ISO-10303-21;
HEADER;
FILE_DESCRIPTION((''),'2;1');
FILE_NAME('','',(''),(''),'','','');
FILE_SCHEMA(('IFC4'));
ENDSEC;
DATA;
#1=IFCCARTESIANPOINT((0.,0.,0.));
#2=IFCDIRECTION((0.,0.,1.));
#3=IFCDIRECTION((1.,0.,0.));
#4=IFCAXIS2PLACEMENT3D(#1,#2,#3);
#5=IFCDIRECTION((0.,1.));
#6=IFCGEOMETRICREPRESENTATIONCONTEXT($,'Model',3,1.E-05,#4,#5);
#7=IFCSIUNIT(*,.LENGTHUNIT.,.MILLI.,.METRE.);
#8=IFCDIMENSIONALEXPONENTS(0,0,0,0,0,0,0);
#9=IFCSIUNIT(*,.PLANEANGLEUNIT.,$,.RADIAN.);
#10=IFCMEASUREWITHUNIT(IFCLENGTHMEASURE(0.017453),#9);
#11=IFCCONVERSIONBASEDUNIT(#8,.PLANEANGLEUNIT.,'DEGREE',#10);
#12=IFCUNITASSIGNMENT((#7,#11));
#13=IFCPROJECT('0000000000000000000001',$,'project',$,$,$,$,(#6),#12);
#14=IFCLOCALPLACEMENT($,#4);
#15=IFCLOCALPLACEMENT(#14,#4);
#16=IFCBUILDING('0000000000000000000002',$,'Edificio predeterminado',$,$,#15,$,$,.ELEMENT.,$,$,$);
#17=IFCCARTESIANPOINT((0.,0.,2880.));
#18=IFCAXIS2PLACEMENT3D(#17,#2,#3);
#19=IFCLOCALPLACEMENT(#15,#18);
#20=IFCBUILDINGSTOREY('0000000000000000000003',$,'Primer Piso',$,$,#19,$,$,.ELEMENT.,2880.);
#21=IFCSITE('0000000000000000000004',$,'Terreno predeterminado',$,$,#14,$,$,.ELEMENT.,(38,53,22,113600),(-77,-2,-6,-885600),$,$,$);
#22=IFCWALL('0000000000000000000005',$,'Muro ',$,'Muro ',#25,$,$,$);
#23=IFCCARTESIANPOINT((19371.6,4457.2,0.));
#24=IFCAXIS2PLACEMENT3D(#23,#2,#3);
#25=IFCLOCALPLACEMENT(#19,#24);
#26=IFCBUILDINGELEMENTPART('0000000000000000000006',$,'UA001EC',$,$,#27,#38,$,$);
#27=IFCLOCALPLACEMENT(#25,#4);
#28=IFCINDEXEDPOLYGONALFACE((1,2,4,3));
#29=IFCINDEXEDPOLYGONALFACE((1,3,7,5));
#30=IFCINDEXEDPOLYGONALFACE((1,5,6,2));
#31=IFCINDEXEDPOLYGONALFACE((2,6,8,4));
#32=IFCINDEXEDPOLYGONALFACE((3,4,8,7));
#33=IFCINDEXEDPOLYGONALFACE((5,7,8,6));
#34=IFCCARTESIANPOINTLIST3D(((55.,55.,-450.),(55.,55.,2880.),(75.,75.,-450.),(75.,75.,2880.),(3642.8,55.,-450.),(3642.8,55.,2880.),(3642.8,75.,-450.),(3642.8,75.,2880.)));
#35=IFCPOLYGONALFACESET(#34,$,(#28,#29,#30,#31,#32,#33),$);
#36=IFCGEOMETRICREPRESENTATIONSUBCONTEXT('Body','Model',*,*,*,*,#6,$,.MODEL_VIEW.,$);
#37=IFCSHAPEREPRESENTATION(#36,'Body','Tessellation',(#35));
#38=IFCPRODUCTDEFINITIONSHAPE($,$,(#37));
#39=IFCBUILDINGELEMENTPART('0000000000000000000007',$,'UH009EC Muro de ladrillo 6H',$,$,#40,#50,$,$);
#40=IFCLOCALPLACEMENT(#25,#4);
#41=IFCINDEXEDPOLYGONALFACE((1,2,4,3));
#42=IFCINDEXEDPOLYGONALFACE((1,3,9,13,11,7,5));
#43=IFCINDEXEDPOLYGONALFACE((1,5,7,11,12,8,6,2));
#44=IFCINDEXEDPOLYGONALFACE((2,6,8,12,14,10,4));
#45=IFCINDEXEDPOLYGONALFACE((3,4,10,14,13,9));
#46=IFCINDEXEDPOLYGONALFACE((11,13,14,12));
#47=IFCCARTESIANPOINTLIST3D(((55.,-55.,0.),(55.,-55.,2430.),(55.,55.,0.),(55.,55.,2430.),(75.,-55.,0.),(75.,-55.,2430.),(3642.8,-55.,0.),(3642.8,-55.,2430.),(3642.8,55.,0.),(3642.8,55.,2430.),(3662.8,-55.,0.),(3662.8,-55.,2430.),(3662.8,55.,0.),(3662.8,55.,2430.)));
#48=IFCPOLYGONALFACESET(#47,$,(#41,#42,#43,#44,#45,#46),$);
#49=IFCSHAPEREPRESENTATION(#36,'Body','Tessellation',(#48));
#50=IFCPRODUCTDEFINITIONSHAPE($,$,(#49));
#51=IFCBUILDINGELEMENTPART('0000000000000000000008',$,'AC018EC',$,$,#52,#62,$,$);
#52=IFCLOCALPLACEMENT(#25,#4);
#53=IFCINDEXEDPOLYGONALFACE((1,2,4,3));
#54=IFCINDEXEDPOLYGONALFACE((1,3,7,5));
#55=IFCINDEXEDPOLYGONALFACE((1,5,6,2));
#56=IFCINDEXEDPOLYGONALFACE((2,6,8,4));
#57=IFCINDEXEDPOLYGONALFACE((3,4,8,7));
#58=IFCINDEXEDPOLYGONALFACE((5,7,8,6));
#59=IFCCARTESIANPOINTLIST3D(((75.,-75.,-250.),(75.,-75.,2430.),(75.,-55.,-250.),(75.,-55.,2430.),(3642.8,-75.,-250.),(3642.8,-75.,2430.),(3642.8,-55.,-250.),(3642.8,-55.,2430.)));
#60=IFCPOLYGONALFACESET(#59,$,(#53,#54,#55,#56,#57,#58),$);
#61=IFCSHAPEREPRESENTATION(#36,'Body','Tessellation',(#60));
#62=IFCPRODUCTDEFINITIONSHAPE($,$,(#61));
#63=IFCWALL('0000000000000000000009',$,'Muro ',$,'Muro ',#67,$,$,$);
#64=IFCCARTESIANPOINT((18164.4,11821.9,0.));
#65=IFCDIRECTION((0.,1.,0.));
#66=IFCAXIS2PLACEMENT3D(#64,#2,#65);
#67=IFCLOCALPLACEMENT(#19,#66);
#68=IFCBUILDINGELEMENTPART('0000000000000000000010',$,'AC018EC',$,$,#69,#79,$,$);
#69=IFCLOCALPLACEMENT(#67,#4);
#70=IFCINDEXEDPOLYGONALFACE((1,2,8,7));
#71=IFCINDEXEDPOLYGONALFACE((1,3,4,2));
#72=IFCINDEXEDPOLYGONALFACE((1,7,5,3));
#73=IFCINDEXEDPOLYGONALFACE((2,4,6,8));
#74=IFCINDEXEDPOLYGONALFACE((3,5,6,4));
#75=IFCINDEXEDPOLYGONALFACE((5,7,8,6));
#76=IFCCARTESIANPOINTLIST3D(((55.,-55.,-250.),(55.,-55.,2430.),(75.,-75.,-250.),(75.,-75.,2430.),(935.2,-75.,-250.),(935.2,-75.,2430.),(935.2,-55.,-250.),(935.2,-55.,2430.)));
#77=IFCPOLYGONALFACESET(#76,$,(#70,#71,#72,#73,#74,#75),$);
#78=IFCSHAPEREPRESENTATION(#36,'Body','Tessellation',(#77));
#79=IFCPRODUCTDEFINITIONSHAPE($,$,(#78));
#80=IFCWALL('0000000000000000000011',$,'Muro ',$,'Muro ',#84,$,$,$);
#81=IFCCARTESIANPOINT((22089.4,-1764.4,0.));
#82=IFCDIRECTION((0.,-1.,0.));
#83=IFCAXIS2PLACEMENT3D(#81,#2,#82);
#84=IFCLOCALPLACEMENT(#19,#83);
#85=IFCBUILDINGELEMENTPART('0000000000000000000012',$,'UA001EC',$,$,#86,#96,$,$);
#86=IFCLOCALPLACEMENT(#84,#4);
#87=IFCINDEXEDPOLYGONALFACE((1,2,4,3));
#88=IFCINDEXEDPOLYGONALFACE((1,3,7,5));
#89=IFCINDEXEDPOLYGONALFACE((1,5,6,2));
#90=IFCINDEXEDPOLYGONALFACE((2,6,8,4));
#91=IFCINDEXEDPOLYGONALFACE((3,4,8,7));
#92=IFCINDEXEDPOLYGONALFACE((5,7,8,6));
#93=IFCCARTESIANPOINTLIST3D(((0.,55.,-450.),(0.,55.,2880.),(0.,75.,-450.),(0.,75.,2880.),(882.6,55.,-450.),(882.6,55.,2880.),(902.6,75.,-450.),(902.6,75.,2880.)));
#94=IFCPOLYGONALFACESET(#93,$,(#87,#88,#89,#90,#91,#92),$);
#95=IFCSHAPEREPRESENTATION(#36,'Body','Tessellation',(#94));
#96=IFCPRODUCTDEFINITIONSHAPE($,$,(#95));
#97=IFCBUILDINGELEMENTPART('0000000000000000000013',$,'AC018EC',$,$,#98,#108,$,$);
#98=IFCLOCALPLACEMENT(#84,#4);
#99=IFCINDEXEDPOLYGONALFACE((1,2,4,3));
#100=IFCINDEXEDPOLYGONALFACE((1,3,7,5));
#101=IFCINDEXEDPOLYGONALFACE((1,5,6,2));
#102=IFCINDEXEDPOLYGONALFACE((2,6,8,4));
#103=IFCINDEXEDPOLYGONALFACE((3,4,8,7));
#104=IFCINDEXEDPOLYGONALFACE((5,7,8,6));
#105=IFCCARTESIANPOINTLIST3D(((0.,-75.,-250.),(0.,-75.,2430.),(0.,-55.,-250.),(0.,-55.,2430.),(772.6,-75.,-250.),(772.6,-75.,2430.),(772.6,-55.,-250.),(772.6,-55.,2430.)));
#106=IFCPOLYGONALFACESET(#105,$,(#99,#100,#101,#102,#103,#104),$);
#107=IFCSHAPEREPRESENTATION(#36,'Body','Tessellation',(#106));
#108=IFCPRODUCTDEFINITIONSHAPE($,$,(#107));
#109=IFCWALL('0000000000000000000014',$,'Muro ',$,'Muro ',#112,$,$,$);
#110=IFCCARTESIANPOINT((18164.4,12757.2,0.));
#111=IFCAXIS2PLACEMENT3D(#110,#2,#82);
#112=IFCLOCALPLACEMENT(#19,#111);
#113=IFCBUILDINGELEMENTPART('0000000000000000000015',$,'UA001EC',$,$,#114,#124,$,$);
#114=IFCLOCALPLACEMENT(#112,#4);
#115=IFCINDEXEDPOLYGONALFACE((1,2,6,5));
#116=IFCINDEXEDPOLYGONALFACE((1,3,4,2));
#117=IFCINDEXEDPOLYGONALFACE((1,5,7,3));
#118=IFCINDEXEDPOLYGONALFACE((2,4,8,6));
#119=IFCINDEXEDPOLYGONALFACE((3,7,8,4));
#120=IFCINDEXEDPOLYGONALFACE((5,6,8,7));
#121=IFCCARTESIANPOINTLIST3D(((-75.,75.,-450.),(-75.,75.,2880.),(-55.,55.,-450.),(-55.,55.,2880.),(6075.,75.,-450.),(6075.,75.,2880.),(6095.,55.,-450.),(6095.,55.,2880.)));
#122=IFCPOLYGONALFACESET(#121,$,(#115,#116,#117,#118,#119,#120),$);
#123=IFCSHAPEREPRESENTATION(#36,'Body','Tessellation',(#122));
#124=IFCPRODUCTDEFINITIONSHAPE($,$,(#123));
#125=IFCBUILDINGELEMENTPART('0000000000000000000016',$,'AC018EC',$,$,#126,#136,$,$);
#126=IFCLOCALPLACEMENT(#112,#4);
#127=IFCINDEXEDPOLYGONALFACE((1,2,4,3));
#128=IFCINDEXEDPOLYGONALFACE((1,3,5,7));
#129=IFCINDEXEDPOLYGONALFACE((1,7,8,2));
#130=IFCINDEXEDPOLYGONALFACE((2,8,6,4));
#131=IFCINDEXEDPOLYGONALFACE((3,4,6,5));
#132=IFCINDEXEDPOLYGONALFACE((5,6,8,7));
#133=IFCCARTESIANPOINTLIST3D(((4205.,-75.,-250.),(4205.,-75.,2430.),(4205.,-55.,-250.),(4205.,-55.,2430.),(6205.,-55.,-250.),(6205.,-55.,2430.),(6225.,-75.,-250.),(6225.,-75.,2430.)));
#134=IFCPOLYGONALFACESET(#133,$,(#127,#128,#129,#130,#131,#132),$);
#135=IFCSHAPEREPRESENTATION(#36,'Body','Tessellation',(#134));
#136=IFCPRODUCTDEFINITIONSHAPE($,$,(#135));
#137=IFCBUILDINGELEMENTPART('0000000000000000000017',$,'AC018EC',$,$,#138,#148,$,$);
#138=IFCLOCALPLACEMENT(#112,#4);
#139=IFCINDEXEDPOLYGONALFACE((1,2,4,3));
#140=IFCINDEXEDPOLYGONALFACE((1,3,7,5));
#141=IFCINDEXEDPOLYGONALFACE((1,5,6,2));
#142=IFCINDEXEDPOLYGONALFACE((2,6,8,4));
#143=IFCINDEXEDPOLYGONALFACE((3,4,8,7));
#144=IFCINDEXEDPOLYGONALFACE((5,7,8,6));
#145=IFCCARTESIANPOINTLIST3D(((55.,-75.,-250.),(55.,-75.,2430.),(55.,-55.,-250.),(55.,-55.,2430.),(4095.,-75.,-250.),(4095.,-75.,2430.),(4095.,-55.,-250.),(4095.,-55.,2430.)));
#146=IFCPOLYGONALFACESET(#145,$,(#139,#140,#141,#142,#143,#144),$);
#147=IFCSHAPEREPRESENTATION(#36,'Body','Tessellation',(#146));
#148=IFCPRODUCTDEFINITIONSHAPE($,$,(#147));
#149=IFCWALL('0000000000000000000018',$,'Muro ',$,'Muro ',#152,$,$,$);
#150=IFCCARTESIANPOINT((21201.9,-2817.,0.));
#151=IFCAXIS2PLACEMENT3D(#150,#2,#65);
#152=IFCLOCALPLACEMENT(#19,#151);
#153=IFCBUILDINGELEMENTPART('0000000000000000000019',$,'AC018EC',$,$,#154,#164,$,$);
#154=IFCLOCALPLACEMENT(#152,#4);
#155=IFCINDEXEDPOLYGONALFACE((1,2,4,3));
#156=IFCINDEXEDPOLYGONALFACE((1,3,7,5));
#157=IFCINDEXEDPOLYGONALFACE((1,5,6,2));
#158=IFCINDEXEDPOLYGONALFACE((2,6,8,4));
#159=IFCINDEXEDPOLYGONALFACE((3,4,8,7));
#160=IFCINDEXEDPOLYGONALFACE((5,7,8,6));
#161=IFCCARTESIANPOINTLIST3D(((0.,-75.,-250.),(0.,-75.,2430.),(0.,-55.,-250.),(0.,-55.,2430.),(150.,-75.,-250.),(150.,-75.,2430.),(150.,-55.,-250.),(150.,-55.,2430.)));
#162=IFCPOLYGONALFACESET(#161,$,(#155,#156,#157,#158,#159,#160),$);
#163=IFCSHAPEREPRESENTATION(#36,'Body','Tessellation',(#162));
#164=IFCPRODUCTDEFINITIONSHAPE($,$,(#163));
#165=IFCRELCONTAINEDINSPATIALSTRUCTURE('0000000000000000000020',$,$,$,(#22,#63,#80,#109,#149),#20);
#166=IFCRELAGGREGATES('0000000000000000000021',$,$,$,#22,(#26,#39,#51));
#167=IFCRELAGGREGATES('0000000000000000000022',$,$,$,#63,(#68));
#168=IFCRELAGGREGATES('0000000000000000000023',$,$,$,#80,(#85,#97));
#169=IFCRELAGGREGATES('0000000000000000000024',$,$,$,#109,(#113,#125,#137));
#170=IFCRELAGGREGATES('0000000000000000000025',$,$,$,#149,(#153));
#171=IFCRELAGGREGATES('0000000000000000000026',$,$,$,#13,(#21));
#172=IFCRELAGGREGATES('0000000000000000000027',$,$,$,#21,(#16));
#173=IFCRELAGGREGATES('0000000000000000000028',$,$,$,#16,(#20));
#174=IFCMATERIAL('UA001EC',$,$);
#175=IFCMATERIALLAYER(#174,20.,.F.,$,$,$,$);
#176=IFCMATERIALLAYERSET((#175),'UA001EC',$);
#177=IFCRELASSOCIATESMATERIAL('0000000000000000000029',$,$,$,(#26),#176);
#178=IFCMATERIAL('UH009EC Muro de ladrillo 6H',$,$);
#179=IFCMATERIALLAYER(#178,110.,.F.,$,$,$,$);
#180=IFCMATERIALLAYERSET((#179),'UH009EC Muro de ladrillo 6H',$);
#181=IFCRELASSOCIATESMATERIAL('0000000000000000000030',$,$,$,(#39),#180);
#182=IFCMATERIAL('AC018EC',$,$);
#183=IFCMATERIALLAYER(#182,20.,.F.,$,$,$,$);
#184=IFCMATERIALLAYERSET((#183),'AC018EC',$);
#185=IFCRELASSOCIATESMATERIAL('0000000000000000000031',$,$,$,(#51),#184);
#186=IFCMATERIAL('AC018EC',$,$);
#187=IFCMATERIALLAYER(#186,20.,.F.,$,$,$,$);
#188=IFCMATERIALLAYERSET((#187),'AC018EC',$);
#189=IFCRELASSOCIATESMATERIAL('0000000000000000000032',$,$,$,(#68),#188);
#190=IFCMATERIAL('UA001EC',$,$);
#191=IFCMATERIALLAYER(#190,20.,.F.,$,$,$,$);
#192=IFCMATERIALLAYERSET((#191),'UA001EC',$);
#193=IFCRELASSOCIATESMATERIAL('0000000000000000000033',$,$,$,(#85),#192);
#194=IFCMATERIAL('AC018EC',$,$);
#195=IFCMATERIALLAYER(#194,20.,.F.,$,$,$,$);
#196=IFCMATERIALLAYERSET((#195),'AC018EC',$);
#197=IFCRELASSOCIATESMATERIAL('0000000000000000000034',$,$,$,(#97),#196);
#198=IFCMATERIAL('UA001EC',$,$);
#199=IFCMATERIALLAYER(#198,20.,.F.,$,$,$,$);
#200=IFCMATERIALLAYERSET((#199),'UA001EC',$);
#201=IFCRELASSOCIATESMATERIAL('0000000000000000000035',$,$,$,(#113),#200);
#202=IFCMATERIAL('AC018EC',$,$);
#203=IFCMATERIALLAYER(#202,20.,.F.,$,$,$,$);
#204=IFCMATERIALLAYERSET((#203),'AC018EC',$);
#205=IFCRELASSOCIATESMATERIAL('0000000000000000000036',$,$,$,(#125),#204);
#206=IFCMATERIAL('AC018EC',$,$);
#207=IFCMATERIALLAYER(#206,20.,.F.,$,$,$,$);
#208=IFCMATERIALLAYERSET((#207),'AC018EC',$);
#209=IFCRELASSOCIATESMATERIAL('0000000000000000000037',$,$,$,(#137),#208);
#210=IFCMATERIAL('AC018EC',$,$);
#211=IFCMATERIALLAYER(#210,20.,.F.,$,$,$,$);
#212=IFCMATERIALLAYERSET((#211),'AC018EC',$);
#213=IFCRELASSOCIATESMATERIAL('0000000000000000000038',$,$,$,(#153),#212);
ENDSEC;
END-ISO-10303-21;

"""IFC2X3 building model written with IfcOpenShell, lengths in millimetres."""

from ifc_helpers import new_model, entity, si_unit, converted_unit, direction, frame, origin_with_axes, place, context, subcontext, project, spatial, polyline, outline, extrude, clip, bounded_halfspace, material, layer, layer_set, layer_usage, element, aggregate, save


model = new_model("IFC2X3")

# Units and contexts
model_context = context("Model", 3, precision=1e-05, world=origin_with_axes(), true_north=direction((0.0, 1.0)))
body_context = subcontext(model_context, "Body", "Model", "MODEL_VIEW")
ifc_project = project(units=[si_unit("LENGTHUNIT", "METRE", prefix="MILLI"), converted_unit("PLANEANGLEUNIT", "DEGREE", entity("IfcLengthMeasure", 0.017453), si_unit("PLANEANGLEUNIT", "RADIAN"), dimensions=[0, 0, 0, 0, 0, 0, 0])], contexts=[model_context])

# Site, building, storey
site_placement = place(None, origin_with_axes())
site = spatial("IfcSite", under=ifc_project, at=site_placement, Name="Terreno predeterminado", CompositionType="ELEMENT", RefLatitude=(38, 53, 22, 113600), RefLongitude=(-77, -2, -6, -885600))
building_placement = place(site_placement, origin_with_axes())
building = spatial("IfcBuilding", under=site, at=building_placement, Name="Edificio predeterminado", CompositionType="ELEMENT")
storey_placement = place(building_placement, frame((0.0, 0.0, 2880.0), z_axis=(0.0, 0.0, 1.0), x_axis=(1.0, 0.0, 0.0)))
storey = spatial("IfcBuildingStorey", under=building, at=storey_placement, Name="Primer Piso", CompositionType="ELEMENT", Elevation=2880.0)

# Walls, building element parts
wall_1_placement = place(storey_placement, frame((19371.6, 4457.2, 0.0), z_axis=(0.0, 0.0, 1.0), x_axis=(1.0, 0.0, 0.0)))
wall_1 = element("IfcWall", 1, at=wall_1_placement, inside=storey, Name="Muro ", ObjectType="Muro ")
ifc_material_1 = material(Name="UA001EC")
ifc_layer_1 = layer(ifc_material_1, 20.0, ventilated=False)
ifc_layer_set_1 = layer_set([ifc_layer_1], Name="UA001EC")
ifc_layer_usage_1 = layer_usage(ifc_layer_set_1, "AXIS2", "NEGATIVE", -75.0)
building_element_part_1_placement = place(wall_1_placement, origin_with_axes())
building_element_part_1 = element("IfcBuildingElementPart", 2, at=building_element_part_1_placement, material=ifc_layer_usage_1, Name="UA001EC", context=body_context, shape_type="SweptSolid", body=[
    extrude(outline(polyline([(3642.8, 75.0), (3642.8, 55.0), (55.0, 55.0), (75.0, 75.0), (3642.8, 75.0)])), frame((0.0, 0.0, -450.0), z_axis=(0.0, 0.0, 1.0), x_axis=(1.0, 0.0, 0.0)), (0.0, 0.0, 1.0), 3330.0),
])
ifc_material_2 = material(Name="UH009EC Muro de ladrillo 6H")
ifc_layer_2 = layer(ifc_material_2, 110.0, ventilated=False)
ifc_layer_set_2 = layer_set([ifc_layer_2], Name="UH009EC Muro de ladrillo 6H")
ifc_layer_usage_2 = layer_usage(ifc_layer_set_2, "AXIS2", "NEGATIVE", -55.0)
building_element_part_2_placement = place(wall_1_placement, origin_with_axes())
building_element_part_2 = element("IfcBuildingElementPart", 3, at=building_element_part_2_placement, material=ifc_layer_usage_2, Name="UH009EC Muro de ladrillo 6H", context=body_context, shape_type="SweptSolid", body=[
    extrude(outline(polyline([(3662.8, 55.0), (3662.8, -55.0), (3642.8, -55.0), (75.0, -55.0), (55.0, -55.0), (55.0, 55.0), (3642.8, 55.0), (3662.8, 55.0)])), origin_with_axes(), (0.0, 0.0, 1.0), 2430.0),
])
ifc_material_3 = material(Name="AC018EC")
ifc_layer_3 = layer(ifc_material_3, 20.0, ventilated=False)
ifc_layer_set_3 = layer_set([ifc_layer_3], Name="AC018EC")
ifc_layer_usage_3 = layer_usage(ifc_layer_set_3, "AXIS2", "NEGATIVE", 55.0)
building_element_part_3_placement = place(wall_1_placement, origin_with_axes())
building_element_part_3 = element("IfcBuildingElementPart", 4, at=building_element_part_3_placement, material=ifc_layer_usage_3, Name="AC018EC", context=body_context, shape_type="SweptSolid", body=[
    extrude(outline(polyline([(3642.8, -55.0), (3642.8, -75.0), (75.0, -75.0), (75.0, -55.0), (3642.8, -55.0)])), frame((0.0, 0.0, -250.0), z_axis=(0.0, 0.0, 1.0), x_axis=(1.0, 0.0, 0.0)), (0.0, 0.0, 1.0), 2680.0),
])
aggregate(wall_1, [building_element_part_1, building_element_part_2, building_element_part_3])
wall_2_placement = place(storey_placement, frame((18164.4, 11821.9, 0.0), z_axis=(0.0, 0.0, 1.0), x_axis=(0.0, 1.0, 0.0)))
wall_2 = element("IfcWall", 5, at=wall_2_placement, inside=storey, Name="Muro ", ObjectType="Muro ")
ifc_material_4 = material(Name="AC018EC")
ifc_layer_4 = layer(ifc_material_4, 20.0, ventilated=False)
ifc_layer_set_4 = layer_set([ifc_layer_4], Name="AC018EC")
ifc_layer_usage_4 = layer_usage(ifc_layer_set_4, "AXIS2", "NEGATIVE", 55.0)
building_element_part_4_placement = place(wall_2_placement, origin_with_axes())
building_element_part_4 = element("IfcBuildingElementPart", 6, at=building_element_part_4_placement, material=ifc_layer_usage_4, Name="AC018EC", context=body_context, shape_type="SweptSolid", body=[
    extrude(outline(polyline([(935.2, -55.0), (935.2, -75.0), (75.0, -75.0), (55.0, -55.0), (935.2, -55.0)])), frame((0.0, 0.0, -250.0), z_axis=(0.0, 0.0, 1.0), x_axis=(1.0, 0.0, 0.0)), (0.0, 0.0, 1.0), 2680.0),
])
aggregate(wall_2, [building_element_part_4])
wall_3_placement = place(storey_placement, frame((22089.4, -1764.4, 0.0), z_axis=(0.0, 0.0, 1.0), x_axis=(0.0, -1.0, 0.0)))
wall_3 = element("IfcWall", 7, at=wall_3_placement, inside=storey, Name="Muro ", ObjectType="Muro ")
ifc_material_5 = material(Name="UA001EC")
ifc_layer_5 = layer(ifc_material_5, 20.0, ventilated=False)
ifc_layer_set_5 = layer_set([ifc_layer_5], Name="UA001EC")
ifc_layer_usage_5 = layer_usage(ifc_layer_set_5, "AXIS2", "NEGATIVE", -75.0)
building_element_part_5_placement = place(wall_3_placement, origin_with_axes())
building_element_part_5 = element("IfcBuildingElementPart", 8, at=building_element_part_5_placement, material=ifc_layer_usage_5, Name="UA001EC", context=body_context, shape_type="SweptSolid", body=[
    extrude(outline(polyline([(902.6, 75.0), (882.6, 55.0), (0.0, 55.0), (0.0, 75.0), (902.6, 75.0)])), frame((0.0, 0.0, -450.0), z_axis=(0.0, 0.0, 1.0), x_axis=(1.0, 0.0, 0.0)), (0.0, 0.0, 1.0), 3330.0),
])
ifc_material_6 = material(Name="AC018EC")
ifc_layer_6 = layer(ifc_material_6, 20.0, ventilated=False)
ifc_layer_set_6 = layer_set([ifc_layer_6], Name="AC018EC")
ifc_layer_usage_6 = layer_usage(ifc_layer_set_6, "AXIS2", "NEGATIVE", 55.0)
building_element_part_6_placement = place(wall_3_placement, origin_with_axes())
building_element_part_6 = element("IfcBuildingElementPart", 9, at=building_element_part_6_placement, material=ifc_layer_usage_6, Name="AC018EC", context=body_context, shape_type="SweptSolid", body=[
    extrude(outline(polyline([(772.6, -55.0), (772.6, -75.0), (0.0, -75.0), (0.0, -55.0), (772.6, -55.0)])), frame((0.0, 0.0, -250.0), z_axis=(0.0, 0.0, 1.0), x_axis=(1.0, 0.0, 0.0)), (0.0, 0.0, 1.0), 2680.0),
])
aggregate(wall_3, [building_element_part_5, building_element_part_6])
wall_4_placement = place(storey_placement, frame((18164.4, 12757.2, 0.0), z_axis=(0.0, 0.0, 1.0), x_axis=(0.0, -1.0, 0.0)))
wall_4 = element("IfcWall", 10, at=wall_4_placement, inside=storey, Name="Muro ", ObjectType="Muro ")
ifc_material_7 = material(Name="UA001EC")
ifc_layer_7 = layer(ifc_material_7, 20.0, ventilated=False)
ifc_layer_set_7 = layer_set([ifc_layer_7], Name="UA001EC")
ifc_layer_usage_7 = layer_usage(ifc_layer_set_7, "AXIS2", "NEGATIVE", -75.0)
building_element_part_7_placement = place(wall_4_placement, origin_with_axes())
building_element_part_7 = element("IfcBuildingElementPart", 11, at=building_element_part_7_placement, material=ifc_layer_usage_7, Name="UA001EC", context=body_context, shape_type="SweptSolid", body=[
    extrude(outline(polyline([(6075.0, 75.0), (6095.0, 55.0), (-55.0, 55.0), (-75.0, 75.0), (6075.0, 75.0)])), frame((0.0, 0.0, -450.0), z_axis=(0.0, 0.0, 1.0), x_axis=(1.0, 0.0, 0.0)), (0.0, 0.0, 1.0), 3330.0),
])
ifc_material_8 = material(Name="AC018EC")
ifc_layer_8 = layer(ifc_material_8, 20.0, ventilated=False)
ifc_layer_set_8 = layer_set([ifc_layer_8], Name="AC018EC")
ifc_layer_usage_8 = layer_usage(ifc_layer_set_8, "AXIS2", "NEGATIVE", 55.0)
building_element_part_8_placement = place(wall_4_placement, origin_with_axes())
building_element_part_8 = element("IfcBuildingElementPart", 12, at=building_element_part_8_placement, material=ifc_layer_usage_8, Name="AC018EC", context=body_context, shape_type="SweptSolid", body=[
    extrude(outline(polyline([(6205.0, -55.0), (6225.0, -75.0), (4205.0, -75.0), (4205.0, -55.0), (6205.0, -55.0)])), frame((0.0, 0.0, -250.0), z_axis=(0.0, 0.0, 1.0), x_axis=(1.0, 0.0, 0.0)), (0.0, 0.0, 1.0), 2680.0),
])
ifc_material_9 = material(Name="AC018EC")
ifc_layer_9 = layer(ifc_material_9, 20.0, ventilated=False)
ifc_layer_set_9 = layer_set([ifc_layer_9], Name="AC018EC")
ifc_layer_usage_9 = layer_usage(ifc_layer_set_9, "AXIS2", "NEGATIVE", 55.0)
building_element_part_9_placement = place(wall_4_placement, origin_with_axes())
building_element_part_9 = element("IfcBuildingElementPart", 13, at=building_element_part_9_placement, material=ifc_layer_usage_9, Name="AC018EC", context=body_context, shape_type="SweptSolid", body=[
    extrude(outline(polyline([(4095.0, -55.0), (4095.0, -75.0), (55.0, -75.0), (55.0, -55.0), (4095.0, -55.0)])), frame((0.0, 0.0, -250.0), z_axis=(0.0, 0.0, 1.0), x_axis=(1.0, 0.0, 0.0)), (0.0, 0.0, 1.0), 2680.0),
])
aggregate(wall_4, [building_element_part_7, building_element_part_8, building_element_part_9])
wall_5_placement = place(storey_placement, frame((21201.9, -2817.0, 0.0), z_axis=(0.0, 0.0, 1.0), x_axis=(0.0, 1.0, 0.0)))
wall_5 = element("IfcWall", 14, at=wall_5_placement, inside=storey, Name="Muro ", ObjectType="Muro ")
ifc_material_10 = material(Name="AC018EC")
ifc_layer_10 = layer(ifc_material_10, 20.0, ventilated=False)
ifc_layer_set_10 = layer_set([ifc_layer_10], Name="AC018EC")
ifc_layer_usage_10 = layer_usage(ifc_layer_set_10, "AXIS2", "NEGATIVE", 55.0)
building_element_part_10_placement = place(wall_5_placement, origin_with_axes())
building_element_part_10 = element("IfcBuildingElementPart", 15, at=building_element_part_10_placement, material=ifc_layer_usage_10, Name="AC018EC", context=body_context, shape_type="Clipping", body=[
    clip(clip(extrude(outline(polyline([(150.0, -55.0), (150.0, -75.0), (0.0, -75.0), (0.0, -55.0), (150.0, -55.0)])), frame((0.0, 0.0, -250.0), z_axis=(0.0, 0.0, 1.0), x_axis=(1.0, 0.0, 0.0)), (0.0, 0.0, 1.0), 2680.0), bounded_halfspace(frame((0.0, 0.0, -250.0), z_axis=(0.0, 0.0, 1.0), x_axis=(1.0, 0.0, 0.0)), True, origin_with_axes(), polyline([(-150.0, -150.0), (375.0, -150.0), (375.0, 150.0), (-150.0, 150.0), (-150.0, -150.0)]))), bounded_halfspace(frame((0.0, 0.0, 2430.0), z_axis=(0.0, 0.0, 1.0), x_axis=(1.0, 0.0, 0.0)), False, origin_with_axes(), polyline([(-150.0, -150.0), (375.0, -150.0), (375.0, 150.0), (-150.0, 150.0), (-150.0, -150.0)]))),
])
aggregate(wall_5, [building_element_part_10])

save(model, "model.ifc")
